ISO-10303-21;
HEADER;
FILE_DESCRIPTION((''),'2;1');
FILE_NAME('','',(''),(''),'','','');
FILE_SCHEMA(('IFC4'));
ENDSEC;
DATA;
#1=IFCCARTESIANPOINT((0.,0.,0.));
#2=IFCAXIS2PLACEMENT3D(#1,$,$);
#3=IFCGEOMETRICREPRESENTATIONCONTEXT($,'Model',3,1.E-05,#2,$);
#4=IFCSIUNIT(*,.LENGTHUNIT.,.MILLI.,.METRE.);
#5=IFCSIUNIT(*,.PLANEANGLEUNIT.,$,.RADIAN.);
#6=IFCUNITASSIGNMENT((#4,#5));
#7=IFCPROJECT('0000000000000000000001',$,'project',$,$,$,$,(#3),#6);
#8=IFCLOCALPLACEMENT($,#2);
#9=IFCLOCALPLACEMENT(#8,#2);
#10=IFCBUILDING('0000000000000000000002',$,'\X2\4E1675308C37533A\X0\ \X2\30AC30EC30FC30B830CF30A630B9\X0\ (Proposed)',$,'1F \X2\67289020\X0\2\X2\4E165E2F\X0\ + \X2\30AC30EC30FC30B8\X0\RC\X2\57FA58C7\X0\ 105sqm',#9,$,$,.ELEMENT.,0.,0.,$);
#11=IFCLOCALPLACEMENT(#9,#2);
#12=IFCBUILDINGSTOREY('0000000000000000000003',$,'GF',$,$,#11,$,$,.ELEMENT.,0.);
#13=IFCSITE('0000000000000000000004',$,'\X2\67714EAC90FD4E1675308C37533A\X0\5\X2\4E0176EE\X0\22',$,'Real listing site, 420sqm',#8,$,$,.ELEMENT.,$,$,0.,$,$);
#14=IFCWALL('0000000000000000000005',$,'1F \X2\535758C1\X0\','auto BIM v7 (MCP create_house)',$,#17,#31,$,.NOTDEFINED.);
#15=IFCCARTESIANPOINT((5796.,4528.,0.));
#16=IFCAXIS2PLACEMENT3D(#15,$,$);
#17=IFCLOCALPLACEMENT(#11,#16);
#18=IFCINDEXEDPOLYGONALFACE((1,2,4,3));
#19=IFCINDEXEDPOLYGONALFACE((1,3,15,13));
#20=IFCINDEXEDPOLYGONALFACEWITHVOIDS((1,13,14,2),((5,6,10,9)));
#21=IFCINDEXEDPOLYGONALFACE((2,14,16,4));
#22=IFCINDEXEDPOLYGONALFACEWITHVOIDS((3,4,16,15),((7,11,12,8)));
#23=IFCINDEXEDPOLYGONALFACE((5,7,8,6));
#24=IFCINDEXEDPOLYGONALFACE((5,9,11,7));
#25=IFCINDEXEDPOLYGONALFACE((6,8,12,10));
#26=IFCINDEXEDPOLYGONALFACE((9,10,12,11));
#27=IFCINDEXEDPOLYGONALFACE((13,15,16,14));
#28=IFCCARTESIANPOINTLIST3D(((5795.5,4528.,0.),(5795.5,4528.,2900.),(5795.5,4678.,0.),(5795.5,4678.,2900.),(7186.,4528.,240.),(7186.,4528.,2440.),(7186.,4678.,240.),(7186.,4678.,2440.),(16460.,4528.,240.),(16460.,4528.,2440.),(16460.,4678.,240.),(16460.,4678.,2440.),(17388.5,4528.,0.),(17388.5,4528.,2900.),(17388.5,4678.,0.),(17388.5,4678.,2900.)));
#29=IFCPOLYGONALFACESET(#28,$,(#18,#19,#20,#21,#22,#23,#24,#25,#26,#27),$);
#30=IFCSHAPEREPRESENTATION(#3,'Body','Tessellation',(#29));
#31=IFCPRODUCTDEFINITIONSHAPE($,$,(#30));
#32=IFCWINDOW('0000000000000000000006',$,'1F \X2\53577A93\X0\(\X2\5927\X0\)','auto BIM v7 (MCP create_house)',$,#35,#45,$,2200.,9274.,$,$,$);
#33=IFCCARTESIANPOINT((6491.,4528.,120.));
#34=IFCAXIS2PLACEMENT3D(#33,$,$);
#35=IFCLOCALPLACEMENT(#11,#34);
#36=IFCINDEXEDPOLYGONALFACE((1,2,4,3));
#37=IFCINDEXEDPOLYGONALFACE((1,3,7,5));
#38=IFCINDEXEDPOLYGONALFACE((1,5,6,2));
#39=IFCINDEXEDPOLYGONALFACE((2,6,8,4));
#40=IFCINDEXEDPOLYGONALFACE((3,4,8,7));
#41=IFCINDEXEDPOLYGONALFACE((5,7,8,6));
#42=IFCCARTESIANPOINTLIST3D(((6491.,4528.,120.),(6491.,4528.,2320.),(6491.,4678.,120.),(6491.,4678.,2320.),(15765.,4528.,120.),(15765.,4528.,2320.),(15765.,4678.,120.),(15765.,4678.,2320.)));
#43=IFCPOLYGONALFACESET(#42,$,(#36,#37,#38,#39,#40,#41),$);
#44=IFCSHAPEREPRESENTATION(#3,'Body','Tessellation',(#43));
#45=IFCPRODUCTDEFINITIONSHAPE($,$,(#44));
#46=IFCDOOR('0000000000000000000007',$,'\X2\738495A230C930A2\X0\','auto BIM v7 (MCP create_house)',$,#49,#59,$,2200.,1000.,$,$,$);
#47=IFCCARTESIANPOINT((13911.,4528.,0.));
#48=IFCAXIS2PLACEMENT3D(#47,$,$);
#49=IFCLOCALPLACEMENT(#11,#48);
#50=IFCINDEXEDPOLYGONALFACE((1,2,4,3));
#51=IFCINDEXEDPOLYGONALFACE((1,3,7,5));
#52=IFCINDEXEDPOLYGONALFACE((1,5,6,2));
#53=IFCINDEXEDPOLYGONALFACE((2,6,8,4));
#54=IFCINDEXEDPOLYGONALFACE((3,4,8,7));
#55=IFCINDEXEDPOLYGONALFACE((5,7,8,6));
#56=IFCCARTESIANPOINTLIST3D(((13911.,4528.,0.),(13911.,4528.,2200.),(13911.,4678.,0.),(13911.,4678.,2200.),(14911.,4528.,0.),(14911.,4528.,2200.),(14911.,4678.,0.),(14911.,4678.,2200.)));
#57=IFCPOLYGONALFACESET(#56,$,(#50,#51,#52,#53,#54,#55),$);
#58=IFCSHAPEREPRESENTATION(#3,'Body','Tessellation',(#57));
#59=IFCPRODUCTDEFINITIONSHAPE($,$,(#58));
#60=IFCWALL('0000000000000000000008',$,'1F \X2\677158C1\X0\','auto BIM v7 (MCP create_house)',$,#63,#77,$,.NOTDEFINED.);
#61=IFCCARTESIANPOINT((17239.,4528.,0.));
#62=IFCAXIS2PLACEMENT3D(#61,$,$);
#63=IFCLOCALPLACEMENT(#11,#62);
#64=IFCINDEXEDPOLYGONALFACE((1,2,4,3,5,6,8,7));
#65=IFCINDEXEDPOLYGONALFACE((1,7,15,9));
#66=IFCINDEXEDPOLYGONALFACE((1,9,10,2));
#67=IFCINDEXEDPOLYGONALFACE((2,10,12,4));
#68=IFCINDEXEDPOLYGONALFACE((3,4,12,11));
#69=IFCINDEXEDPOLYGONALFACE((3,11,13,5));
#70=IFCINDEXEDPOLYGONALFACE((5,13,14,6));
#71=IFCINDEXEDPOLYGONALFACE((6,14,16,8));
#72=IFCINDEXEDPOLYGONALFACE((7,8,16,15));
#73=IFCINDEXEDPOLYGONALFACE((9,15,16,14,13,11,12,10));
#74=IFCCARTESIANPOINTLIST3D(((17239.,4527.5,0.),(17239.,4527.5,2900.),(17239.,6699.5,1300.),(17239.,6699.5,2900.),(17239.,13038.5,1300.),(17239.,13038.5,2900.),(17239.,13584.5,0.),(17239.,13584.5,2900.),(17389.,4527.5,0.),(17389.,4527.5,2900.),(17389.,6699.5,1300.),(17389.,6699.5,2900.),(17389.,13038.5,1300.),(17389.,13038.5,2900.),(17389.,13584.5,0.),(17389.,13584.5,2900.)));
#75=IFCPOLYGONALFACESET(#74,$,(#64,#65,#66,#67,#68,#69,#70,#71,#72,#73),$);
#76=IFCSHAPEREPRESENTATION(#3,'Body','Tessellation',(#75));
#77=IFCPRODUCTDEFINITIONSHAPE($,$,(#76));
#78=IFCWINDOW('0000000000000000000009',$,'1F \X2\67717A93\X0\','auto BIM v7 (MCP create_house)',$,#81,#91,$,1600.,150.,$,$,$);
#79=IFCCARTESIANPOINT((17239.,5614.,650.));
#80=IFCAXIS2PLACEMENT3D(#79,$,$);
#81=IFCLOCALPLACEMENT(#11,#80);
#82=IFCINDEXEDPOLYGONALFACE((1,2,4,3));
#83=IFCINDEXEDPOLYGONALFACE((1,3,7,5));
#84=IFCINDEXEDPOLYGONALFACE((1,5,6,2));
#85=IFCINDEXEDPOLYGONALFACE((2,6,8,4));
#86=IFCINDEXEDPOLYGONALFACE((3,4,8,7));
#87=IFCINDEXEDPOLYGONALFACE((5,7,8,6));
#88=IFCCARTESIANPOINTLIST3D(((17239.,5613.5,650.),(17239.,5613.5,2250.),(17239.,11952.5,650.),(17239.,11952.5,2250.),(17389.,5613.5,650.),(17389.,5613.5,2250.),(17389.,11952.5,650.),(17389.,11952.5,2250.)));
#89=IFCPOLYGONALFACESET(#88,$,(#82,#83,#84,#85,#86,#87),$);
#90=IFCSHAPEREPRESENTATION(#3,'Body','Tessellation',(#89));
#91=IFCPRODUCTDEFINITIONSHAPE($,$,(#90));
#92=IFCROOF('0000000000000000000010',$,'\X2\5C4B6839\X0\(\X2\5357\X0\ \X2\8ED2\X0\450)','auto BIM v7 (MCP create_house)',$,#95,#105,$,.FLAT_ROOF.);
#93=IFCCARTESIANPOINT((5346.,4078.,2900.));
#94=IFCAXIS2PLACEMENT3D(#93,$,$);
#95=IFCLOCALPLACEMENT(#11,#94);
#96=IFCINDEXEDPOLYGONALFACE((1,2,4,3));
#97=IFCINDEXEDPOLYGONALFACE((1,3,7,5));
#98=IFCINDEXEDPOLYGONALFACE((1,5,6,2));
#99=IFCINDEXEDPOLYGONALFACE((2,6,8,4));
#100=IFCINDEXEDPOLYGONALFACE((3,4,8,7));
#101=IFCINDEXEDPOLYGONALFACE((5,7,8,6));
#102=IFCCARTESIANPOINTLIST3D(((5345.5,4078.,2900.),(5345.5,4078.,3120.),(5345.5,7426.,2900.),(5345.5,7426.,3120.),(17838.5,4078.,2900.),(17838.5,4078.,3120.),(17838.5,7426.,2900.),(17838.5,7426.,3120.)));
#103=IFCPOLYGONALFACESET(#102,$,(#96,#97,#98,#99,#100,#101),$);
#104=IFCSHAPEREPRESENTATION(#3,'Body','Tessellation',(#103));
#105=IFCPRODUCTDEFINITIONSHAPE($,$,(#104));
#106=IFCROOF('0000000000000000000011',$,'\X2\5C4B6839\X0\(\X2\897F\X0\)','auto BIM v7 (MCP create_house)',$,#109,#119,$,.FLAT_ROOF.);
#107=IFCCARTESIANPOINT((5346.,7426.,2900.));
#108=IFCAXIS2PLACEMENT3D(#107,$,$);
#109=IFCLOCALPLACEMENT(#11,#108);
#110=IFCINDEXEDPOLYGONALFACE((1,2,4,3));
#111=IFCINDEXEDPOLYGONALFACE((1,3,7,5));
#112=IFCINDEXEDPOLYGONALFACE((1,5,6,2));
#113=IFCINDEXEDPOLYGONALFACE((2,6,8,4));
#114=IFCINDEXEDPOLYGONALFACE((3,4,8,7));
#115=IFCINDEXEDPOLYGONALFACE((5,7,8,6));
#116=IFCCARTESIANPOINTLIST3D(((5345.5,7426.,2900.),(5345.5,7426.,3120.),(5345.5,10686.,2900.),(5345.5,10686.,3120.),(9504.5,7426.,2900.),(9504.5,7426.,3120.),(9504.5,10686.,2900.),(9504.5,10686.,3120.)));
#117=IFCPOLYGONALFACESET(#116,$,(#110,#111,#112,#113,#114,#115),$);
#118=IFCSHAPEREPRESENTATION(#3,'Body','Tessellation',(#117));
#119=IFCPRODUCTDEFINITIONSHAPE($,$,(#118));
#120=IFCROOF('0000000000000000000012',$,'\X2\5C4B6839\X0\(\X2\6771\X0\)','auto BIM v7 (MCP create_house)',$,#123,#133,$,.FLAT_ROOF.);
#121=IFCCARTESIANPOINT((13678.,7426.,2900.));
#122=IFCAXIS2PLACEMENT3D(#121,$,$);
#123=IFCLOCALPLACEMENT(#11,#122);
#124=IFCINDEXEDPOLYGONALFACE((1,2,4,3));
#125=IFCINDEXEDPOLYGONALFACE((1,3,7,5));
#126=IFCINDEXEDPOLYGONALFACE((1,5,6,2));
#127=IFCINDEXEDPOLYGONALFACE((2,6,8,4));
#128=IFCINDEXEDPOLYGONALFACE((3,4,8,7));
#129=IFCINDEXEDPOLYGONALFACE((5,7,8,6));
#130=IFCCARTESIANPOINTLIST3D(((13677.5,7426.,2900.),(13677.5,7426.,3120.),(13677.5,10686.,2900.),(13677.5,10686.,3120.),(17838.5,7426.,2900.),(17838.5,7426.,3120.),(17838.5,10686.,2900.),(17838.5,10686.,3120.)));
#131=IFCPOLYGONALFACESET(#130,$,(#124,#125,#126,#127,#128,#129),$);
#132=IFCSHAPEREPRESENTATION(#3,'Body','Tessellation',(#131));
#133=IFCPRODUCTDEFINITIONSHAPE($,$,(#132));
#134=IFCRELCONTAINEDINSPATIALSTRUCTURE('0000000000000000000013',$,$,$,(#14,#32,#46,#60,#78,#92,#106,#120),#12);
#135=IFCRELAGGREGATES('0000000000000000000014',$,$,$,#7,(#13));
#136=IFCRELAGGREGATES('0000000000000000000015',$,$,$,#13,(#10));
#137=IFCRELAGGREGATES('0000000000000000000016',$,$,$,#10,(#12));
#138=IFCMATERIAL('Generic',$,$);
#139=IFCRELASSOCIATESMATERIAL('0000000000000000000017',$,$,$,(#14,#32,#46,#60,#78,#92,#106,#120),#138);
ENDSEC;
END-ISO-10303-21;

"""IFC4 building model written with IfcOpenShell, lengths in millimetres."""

from ifc_helpers import new_model, si_unit, frame, frame_2d, origin, place, context, project, spatial, rectangle, extrude, material, element, fill, save


model = new_model("IFC4")

# Units and contexts
model_context = context("Model", 3, precision=1e-05, world=origin())
ifc_project = project(units=[si_unit("LENGTHUNIT", "METRE", prefix="MILLI"), si_unit("PLANEANGLEUNIT", "RADIAN")], contexts=[model_context])

# Site, building, storey
site_placement = place(None, origin())
site = spatial("IfcSite", under=ifc_project, at=site_placement, Name="東京都世田谷区5丁目22", ObjectType="Real listing site, 420sqm", CompositionType="ELEMENT", RefElevation=0.0)
building_placement = place(site_placement, origin())
building = spatial("IfcBuilding", under=site, at=building_placement, Name="世田谷区 ガレージハウス (Proposed)", ObjectType="1F 木造2世帯 + ガレージRC基壇 105sqm", CompositionType="ELEMENT", ElevationOfRefHeight=0.0, ElevationOfTerrain=0.0)
storey_placement = place(building_placement, origin())
storey = spatial("IfcBuildingStorey", under=building, at=storey_placement, Name="GF", CompositionType="ELEMENT", Elevation=0.0)

# Shared definitions
ifc_material = material(Name="Generic")

# Wall, openings, window, door
wall_1_placement = place(storey_placement, frame((5796.0, 4528.0, 0.0)))
wall_1 = element("IfcWall", 1, at=wall_1_placement, inside=storey, material=ifc_material, Name="1F 南壁", Description="auto BIM v7 (MCP create_house)", PredefinedType="NOTDEFINED", context=model_context, shape_type="SweptSolid", body=[
    extrude(rectangle(XDim=11593.0, YDim=150.0, at=frame_2d((5796.0, 75.0))), frame((5796.0, 4528.0, 0.0)), (0.0, 0.0, 1.0), 2900.0),
])
opening_1_placement = place(storey_placement, frame((6491.0, 4528.0, 120.0)))
opening_1 = element("IfcOpeningElement", 2, at=opening_1_placement, cuts=wall_1, PredefinedType="NOTDEFINED", context=model_context, shape_type="SweptSolid", body=[
    extrude(rectangle(XDim=9274.0, YDim=150.0, at=frame_2d((4637.0, 75.0))), frame((6491.0, 4528.0, 120.0)), (0.0, 0.0, 1.0), 2200.0),
])
opening_2_placement = place(storey_placement, frame((13911.0, 4528.0, 0.0)))
opening_2 = element("IfcOpeningElement", 3, at=opening_2_placement, cuts=wall_1, PredefinedType="NOTDEFINED", context=model_context, shape_type="SweptSolid", body=[
    extrude(rectangle(XDim=1000.0, YDim=150.0, at=frame_2d((500.0, 75.0))), frame((13911.0, 4528.0, 0.0)), (0.0, 0.0, 1.0), 2200.0),
])
window_1_placement = place(storey_placement, frame((6491.0, 4528.0, 120.0)))
window_1 = element("IfcWindow", 4, at=window_1_placement, inside=storey, material=ifc_material, Name="1F 南窓(大)", Description="auto BIM v7 (MCP create_house)", OverallHeight=2200.0, OverallWidth=9274.0, context=model_context, shape_type="SweptSolid", body=[
    extrude(rectangle(XDim=9274.0, YDim=150.0, at=frame_2d((4637.0, 75.0))), frame((6491.0, 4528.0, 120.0)), (0.0, 0.0, 1.0), 2200.0),
])
fill(opening_1, window_1)
door_placement = place(storey_placement, frame((13911.0, 4528.0, 0.0)))
door = element("IfcDoor", 5, at=door_placement, inside=storey, material=ifc_material, Name="玄関ドア", Description="auto BIM v7 (MCP create_house)", OverallHeight=2200.0, OverallWidth=1000.0, context=model_context, shape_type="SweptSolid", body=[
    extrude(rectangle(XDim=1000.0, YDim=150.0, at=frame_2d((500.0, 75.0))), frame((13911.0, 4528.0, 0.0)), (0.0, 0.0, 1.0), 2200.0),
])
fill(opening_2, door)

# Wall, opening, window
wall_2_placement = place(storey_placement, frame((17239.0, 4528.0, 0.0)))
wall_2 = element("IfcWall", 6, at=wall_2_placement, inside=storey, material=ifc_material, Name="1F 東壁", Description="auto BIM v7 (MCP create_house)", PredefinedType="NOTDEFINED", context=model_context, shape_type="SweptSolid", body=[
    extrude(rectangle(XDim=150.0, YDim=9057.0, at=frame_2d((75.0, 4528.0))), frame((17239.0, 4528.0, 0.0)), (0.0, 0.0, 1.0), 2900.0),
])
opening_3_placement = place(storey_placement, frame((17239.0, 5614.0, 650.0)))
opening_3 = element("IfcOpeningElement", 7, at=opening_3_placement, cuts=wall_2, PredefinedType="NOTDEFINED", context=model_context, shape_type="SweptSolid", body=[
    extrude(rectangle(XDim=150.0, YDim=6339.0, at=frame_2d((75.0, 3169.0))), frame((17239.0, 5614.0, 650.0)), (0.0, 0.0, 1.0), 1600.0),
])
window_2_placement = place(storey_placement, frame((17239.0, 5614.0, 650.0)))
window_2 = element("IfcWindow", 8, at=window_2_placement, inside=storey, material=ifc_material, Name="1F 東窓", Description="auto BIM v7 (MCP create_house)", OverallHeight=1600.0, OverallWidth=150.0, context=model_context, shape_type="SweptSolid", body=[
    extrude(rectangle(XDim=150.0, YDim=6339.0, at=frame_2d((75.0, 3169.0))), frame((17239.0, 5614.0, 650.0)), (0.0, 0.0, 1.0), 1600.0),
])
fill(opening_3, window_2)

# Roofs
roof_1_placement = place(storey_placement, frame((5346.0, 4078.0, 2900.0)))
element("IfcRoof", 9, at=roof_1_placement, inside=storey, material=ifc_material, Name="屋根(南 軒450)", Description="auto BIM v7 (MCP create_house)", PredefinedType="FLAT_ROOF", context=model_context, shape_type="SweptSolid", body=[
    extrude(rectangle(XDim=12493.0, YDim=3348.0, at=frame_2d((6246.0, 1674.0))), frame((5346.0, 4078.0, 2900.0)), (0.0, 0.0, 1.0), 220.0),
])
roof_2_placement = place(storey_placement, frame((5346.0, 7426.0, 2900.0)))
element("IfcRoof", 10, at=roof_2_placement, inside=storey, material=ifc_material, Name="屋根(西)", Description="auto BIM v7 (MCP create_house)", PredefinedType="FLAT_ROOF", context=model_context, shape_type="SweptSolid", body=[
    extrude(rectangle(XDim=4159.0, YDim=3260.0, at=frame_2d((2079.0, 1630.0))), frame((5346.0, 7426.0, 2900.0)), (0.0, 0.0, 1.0), 220.0),
])
roof_3_placement = place(storey_placement, frame((13678.0, 7426.0, 2900.0)))
element("IfcRoof", 11, at=roof_3_placement, inside=storey, material=ifc_material, Name="屋根(東)", Description="auto BIM v7 (MCP create_house)", PredefinedType="FLAT_ROOF", context=model_context, shape_type="SweptSolid", body=[
    extrude(rectangle(XDim=4161.0, YDim=3260.0, at=frame_2d((2080.0, 1630.0))), frame((13678.0, 7426.0, 2900.0)), (0.0, 0.0, 1.0), 220.0),
])

save(model, "model.ifc")
